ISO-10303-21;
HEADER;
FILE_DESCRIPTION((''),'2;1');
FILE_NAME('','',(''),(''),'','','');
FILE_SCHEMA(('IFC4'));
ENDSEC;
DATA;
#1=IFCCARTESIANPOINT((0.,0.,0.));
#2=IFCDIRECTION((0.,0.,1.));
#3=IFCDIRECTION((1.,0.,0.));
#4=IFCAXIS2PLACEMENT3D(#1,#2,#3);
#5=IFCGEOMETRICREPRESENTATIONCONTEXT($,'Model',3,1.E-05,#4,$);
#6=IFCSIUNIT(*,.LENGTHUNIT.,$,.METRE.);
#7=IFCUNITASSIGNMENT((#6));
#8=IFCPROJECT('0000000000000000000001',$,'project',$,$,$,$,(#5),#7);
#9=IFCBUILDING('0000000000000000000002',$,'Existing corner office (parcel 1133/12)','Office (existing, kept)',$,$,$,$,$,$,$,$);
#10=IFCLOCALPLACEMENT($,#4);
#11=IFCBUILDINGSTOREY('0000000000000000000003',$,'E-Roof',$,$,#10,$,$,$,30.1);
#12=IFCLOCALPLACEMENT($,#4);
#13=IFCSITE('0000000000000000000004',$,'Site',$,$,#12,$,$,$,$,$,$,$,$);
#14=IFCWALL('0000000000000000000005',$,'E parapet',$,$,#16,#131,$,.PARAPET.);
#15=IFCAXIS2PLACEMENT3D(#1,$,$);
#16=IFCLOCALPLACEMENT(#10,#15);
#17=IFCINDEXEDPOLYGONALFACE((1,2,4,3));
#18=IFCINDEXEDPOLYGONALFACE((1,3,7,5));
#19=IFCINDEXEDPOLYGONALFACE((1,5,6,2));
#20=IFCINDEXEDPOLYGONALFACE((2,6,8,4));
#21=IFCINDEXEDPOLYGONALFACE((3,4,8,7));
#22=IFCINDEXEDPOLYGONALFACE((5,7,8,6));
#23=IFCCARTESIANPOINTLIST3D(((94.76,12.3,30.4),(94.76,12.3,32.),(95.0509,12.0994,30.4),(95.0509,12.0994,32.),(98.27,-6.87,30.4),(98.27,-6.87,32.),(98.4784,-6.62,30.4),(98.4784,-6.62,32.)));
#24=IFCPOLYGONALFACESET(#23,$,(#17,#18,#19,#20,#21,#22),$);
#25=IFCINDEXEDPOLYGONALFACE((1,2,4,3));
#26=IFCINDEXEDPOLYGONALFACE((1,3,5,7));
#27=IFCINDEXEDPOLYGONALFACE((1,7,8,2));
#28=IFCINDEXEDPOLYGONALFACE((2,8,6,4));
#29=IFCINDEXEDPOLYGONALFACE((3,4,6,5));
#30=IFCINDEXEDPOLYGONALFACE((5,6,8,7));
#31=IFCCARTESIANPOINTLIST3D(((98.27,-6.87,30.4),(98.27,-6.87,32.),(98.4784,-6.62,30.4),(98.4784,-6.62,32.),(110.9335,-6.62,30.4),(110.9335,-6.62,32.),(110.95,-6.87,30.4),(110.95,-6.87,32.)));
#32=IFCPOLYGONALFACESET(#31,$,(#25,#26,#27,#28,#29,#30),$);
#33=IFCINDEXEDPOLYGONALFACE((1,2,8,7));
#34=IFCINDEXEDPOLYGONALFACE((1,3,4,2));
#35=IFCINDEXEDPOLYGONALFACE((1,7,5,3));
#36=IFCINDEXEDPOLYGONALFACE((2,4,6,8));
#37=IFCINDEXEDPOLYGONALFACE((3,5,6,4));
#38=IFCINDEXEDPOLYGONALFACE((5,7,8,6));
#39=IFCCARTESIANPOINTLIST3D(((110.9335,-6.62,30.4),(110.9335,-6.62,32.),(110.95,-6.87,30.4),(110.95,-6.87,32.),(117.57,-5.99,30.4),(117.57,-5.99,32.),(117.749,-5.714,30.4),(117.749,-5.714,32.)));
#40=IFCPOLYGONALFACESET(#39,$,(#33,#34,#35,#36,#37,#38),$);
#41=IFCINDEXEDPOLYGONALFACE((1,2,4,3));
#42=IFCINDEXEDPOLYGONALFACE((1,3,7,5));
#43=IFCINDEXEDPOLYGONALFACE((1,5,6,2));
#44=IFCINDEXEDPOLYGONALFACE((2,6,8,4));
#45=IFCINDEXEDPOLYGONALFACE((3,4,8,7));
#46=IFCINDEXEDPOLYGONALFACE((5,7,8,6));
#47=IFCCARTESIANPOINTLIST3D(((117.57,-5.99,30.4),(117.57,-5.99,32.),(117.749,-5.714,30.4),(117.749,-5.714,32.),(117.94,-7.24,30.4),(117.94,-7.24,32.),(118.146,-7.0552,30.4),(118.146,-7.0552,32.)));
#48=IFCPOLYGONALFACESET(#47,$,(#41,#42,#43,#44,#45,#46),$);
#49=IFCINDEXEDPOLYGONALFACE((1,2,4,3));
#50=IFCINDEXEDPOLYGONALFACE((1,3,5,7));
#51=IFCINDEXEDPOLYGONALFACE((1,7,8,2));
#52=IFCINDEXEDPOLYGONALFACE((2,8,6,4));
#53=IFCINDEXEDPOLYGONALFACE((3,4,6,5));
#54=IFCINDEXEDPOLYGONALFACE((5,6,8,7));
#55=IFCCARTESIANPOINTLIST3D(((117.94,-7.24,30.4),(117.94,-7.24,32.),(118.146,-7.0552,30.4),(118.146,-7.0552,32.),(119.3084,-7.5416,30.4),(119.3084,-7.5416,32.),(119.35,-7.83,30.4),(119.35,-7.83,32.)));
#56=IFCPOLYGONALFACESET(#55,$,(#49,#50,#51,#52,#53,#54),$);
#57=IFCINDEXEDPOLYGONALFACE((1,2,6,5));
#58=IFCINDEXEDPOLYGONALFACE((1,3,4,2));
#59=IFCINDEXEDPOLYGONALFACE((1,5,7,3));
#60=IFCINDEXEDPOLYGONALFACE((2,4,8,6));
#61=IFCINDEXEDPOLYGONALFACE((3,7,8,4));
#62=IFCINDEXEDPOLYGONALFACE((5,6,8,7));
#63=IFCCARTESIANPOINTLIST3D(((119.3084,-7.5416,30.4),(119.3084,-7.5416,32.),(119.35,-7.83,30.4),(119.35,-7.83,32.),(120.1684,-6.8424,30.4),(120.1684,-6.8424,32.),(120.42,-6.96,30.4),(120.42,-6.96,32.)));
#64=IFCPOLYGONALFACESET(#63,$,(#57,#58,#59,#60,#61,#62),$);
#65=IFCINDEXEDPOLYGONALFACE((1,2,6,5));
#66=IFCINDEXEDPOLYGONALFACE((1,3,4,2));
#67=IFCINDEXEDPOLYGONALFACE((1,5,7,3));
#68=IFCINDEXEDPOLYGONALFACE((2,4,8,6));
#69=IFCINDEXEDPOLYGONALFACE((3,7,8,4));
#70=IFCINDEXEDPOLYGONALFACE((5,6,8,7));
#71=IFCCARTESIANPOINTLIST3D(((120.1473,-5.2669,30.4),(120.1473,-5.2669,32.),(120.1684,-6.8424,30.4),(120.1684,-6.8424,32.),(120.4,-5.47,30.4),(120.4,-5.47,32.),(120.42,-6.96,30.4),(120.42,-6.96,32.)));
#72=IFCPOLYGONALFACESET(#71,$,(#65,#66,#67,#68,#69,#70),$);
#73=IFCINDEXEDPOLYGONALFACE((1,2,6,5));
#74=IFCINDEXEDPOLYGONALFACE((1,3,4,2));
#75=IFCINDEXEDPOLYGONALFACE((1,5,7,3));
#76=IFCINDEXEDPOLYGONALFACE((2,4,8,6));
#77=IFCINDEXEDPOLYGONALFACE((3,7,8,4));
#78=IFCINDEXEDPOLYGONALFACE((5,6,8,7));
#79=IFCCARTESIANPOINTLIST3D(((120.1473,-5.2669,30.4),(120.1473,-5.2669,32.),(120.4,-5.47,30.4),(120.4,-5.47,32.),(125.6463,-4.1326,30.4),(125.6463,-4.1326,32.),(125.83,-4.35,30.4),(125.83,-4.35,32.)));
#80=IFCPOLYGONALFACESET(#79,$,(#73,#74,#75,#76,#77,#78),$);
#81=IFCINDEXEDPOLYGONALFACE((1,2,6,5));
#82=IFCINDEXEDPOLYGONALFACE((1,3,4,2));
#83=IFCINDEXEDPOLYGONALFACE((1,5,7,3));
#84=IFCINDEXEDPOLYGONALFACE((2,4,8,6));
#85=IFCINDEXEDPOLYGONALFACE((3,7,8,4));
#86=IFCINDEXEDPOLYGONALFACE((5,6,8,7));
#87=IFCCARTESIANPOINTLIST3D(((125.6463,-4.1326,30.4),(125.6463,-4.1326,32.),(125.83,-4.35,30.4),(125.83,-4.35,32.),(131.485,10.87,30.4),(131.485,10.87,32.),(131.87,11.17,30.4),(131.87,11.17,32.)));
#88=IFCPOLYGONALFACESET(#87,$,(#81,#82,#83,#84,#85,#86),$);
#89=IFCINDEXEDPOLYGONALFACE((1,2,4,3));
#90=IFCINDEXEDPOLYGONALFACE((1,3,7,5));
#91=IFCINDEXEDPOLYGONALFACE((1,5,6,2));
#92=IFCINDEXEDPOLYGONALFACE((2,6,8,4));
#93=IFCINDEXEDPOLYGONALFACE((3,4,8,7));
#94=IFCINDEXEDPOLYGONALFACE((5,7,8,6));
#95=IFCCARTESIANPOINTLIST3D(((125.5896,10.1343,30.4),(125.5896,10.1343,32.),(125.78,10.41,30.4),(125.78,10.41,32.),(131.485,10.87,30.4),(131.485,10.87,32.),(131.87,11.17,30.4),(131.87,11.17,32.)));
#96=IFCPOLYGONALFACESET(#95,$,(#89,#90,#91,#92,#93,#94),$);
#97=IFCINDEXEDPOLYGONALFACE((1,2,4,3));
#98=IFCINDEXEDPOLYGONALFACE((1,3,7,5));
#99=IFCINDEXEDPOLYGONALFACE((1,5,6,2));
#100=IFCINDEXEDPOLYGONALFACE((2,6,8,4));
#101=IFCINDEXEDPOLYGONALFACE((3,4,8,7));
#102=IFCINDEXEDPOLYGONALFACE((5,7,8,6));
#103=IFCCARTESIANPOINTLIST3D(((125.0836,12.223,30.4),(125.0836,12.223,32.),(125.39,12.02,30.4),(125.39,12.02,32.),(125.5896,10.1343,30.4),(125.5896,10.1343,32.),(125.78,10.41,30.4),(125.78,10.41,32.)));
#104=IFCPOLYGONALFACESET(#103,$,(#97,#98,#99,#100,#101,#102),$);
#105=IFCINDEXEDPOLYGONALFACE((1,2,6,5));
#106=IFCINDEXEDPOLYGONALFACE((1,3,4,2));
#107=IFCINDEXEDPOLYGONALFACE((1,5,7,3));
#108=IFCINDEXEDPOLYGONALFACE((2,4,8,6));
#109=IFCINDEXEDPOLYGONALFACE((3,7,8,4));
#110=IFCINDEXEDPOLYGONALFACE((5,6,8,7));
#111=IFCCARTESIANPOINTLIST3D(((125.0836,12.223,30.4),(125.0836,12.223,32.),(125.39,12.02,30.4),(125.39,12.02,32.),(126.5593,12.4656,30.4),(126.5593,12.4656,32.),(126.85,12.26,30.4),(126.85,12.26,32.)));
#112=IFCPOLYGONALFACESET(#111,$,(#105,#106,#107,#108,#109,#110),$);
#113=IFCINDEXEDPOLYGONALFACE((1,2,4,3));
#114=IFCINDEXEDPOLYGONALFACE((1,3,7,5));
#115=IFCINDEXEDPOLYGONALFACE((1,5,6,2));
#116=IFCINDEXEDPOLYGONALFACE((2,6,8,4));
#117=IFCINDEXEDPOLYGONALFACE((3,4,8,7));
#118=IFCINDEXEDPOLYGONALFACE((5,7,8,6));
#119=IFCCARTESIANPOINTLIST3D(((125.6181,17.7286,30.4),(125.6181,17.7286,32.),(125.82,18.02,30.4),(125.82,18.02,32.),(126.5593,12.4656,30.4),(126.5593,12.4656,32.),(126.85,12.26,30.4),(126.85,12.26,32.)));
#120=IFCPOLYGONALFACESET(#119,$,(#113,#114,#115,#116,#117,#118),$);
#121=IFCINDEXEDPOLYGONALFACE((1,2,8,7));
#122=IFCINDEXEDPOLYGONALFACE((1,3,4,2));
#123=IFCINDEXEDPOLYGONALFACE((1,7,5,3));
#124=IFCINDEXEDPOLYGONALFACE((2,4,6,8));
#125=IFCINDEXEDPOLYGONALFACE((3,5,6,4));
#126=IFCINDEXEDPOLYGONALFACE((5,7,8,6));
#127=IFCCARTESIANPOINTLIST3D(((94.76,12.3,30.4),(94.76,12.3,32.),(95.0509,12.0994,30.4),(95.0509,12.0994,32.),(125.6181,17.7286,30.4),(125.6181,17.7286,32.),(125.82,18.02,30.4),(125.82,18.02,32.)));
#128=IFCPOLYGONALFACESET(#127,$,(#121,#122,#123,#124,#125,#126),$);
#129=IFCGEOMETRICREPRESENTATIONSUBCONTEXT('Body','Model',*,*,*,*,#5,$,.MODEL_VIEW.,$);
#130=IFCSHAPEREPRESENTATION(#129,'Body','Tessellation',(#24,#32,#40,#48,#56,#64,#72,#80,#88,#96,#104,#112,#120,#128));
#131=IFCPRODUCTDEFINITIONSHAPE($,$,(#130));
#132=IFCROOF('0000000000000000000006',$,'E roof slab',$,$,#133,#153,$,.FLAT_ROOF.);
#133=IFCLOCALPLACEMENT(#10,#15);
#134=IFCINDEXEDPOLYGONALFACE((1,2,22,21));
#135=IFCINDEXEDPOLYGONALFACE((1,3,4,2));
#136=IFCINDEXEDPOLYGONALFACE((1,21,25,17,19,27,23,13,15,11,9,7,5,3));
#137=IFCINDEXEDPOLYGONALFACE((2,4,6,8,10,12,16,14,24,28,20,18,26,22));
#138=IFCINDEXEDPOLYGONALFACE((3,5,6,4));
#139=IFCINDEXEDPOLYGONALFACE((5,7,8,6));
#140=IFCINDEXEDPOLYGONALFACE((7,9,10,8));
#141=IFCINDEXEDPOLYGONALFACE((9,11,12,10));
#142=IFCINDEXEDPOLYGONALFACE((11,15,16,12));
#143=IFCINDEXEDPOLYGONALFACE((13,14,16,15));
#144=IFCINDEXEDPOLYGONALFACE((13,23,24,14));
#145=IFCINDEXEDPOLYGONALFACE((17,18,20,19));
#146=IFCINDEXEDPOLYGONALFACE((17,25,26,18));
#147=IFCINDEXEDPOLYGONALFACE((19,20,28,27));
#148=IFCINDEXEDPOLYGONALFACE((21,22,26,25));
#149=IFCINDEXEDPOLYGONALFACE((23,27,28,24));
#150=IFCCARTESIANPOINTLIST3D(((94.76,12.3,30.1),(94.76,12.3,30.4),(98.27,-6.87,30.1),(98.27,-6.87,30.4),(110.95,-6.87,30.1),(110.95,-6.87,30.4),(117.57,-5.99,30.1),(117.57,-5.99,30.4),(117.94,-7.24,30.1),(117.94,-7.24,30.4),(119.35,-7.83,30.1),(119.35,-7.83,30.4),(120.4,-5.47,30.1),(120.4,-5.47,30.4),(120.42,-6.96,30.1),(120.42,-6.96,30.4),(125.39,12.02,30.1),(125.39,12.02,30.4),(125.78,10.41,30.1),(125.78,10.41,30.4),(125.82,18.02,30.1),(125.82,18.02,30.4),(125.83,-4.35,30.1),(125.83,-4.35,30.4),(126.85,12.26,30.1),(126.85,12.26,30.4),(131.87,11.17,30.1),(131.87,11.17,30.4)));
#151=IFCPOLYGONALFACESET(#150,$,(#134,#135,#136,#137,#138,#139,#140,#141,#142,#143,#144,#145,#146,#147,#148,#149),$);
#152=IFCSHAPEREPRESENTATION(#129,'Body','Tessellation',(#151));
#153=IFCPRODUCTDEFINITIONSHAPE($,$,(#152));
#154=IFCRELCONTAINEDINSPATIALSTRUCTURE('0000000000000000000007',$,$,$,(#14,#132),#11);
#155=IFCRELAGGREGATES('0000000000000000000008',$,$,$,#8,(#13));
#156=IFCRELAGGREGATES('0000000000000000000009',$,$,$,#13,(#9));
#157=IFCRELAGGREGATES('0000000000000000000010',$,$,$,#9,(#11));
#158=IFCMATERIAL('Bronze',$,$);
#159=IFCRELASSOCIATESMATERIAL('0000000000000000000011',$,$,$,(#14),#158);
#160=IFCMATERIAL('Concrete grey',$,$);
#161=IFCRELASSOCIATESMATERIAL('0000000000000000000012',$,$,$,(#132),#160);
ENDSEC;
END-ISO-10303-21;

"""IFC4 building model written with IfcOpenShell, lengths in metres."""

from ifc_helpers import new_model, si_unit, frame, origin_with_axes, place, context, subcontext, project, spatial, polyline, outline, extrude, material, element, save


model = new_model("IFC4")

# Units and contexts
model_context = context("Model", 3, precision=1e-05, world=origin_with_axes())
body_context = subcontext(model_context, "Body", "Model", "MODEL_VIEW")
ifc_project = project(units=[si_unit("LENGTHUNIT", "METRE")], contexts=[model_context])

# Site, building, storey
site_placement = place(None, origin_with_axes())
site = spatial("IfcSite", under=ifc_project, at=site_placement, Name="Site")
building = spatial("IfcBuilding", under=site, Name="Existing corner office (parcel 1133/12)", Description="Office (existing, kept)")
storey_placement = place(None, origin_with_axes())
storey = spatial("IfcBuildingStorey", under=building, at=storey_placement, Name="E-Roof", Elevation=30.1)

# Wall
ifc_material_1 = material(Name="Bronze")
wall_placement = place(storey_placement, origin_with_axes())
element("IfcWall", 1, at=wall_placement, inside=storey, material=ifc_material_1, Name="E parapet", PredefinedType="PARAPET", context=body_context, shape_type="SweptSolid", body=[
    extrude(outline(polyline([(94.76, 12.3), (98.27, -6.87), (98.4784, -6.62), (95.0509, 12.0994), (94.76, 12.3)])), frame((0.0, 0.0, 30.4), z_axis=(0.0, 0.0, 1.0), x_axis=(1.0, 0.0, 0.0)), (0.0, 0.0, 1.0), 1.6),
    extrude(outline(polyline([(98.27, -6.87), (110.95, -6.87), (110.9335, -6.62), (98.4784, -6.62), (98.27, -6.87)])), frame((0.0, 0.0, 30.4), z_axis=(0.0, 0.0, 1.0), x_axis=(1.0, 0.0, 0.0)), (0.0, 0.0, 1.0), 1.6),
    extrude(outline(polyline([(110.95, -6.87), (117.57, -5.99), (117.749, -5.714), (110.9335, -6.62), (110.95, -6.87)])), frame((0.0, 0.0, 30.4), z_axis=(0.0, 0.0, 1.0), x_axis=(1.0, 0.0, 0.0)), (0.0, 0.0, 1.0), 1.6),
    extrude(outline(polyline([(117.57, -5.99), (117.94, -7.24), (118.146, -7.0552), (117.749, -5.714), (117.57, -5.99)])), frame((0.0, 0.0, 30.4), z_axis=(0.0, 0.0, 1.0), x_axis=(1.0, 0.0, 0.0)), (0.0, 0.0, 1.0), 1.6),
    extrude(outline(polyline([(117.94, -7.24), (119.35, -7.83), (119.3084, -7.5416), (118.146, -7.0552), (117.94, -7.24)])), frame((0.0, 0.0, 30.4), z_axis=(0.0, 0.0, 1.0), x_axis=(1.0, 0.0, 0.0)), (0.0, 0.0, 1.0), 1.6),
    extrude(outline(polyline([(119.35, -7.83), (120.42, -6.96), (120.1684, -6.8424), (119.3084, -7.5416), (119.35, -7.83)])), frame((0.0, 0.0, 30.4), z_axis=(0.0, 0.0, 1.0), x_axis=(1.0, 0.0, 0.0)), (0.0, 0.0, 1.0), 1.6),
    extrude(outline(polyline([(120.42, -6.96), (120.4, -5.47), (120.1473, -5.2669), (120.1684, -6.8424), (120.42, -6.96)])), frame((0.0, 0.0, 30.4), z_axis=(0.0, 0.0, 1.0), x_axis=(1.0, 0.0, 0.0)), (0.0, 0.0, 1.0), 1.6),
    extrude(outline(polyline([(120.4, -5.47), (125.83, -4.35), (125.6463, -4.1326), (120.1473, -5.2669), (120.4, -5.47)])), frame((0.0, 0.0, 30.4), z_axis=(0.0, 0.0, 1.0), x_axis=(1.0, 0.0, 0.0)), (0.0, 0.0, 1.0), 1.6),
    extrude(outline(polyline([(125.83, -4.35), (131.87, 11.17), (131.485, 10.87), (125.6463, -4.1326), (125.83, -4.35)])), frame((0.0, 0.0, 30.4), z_axis=(0.0, 0.0, 1.0), x_axis=(1.0, 0.0, 0.0)), (0.0, 0.0, 1.0), 1.6),
    extrude(outline(polyline([(131.87, 11.17), (125.78, 10.41), (125.5896, 10.1343), (131.485, 10.87), (131.87, 11.17)])), frame((0.0, 0.0, 30.4), z_axis=(0.0, 0.0, 1.0), x_axis=(1.0, 0.0, 0.0)), (0.0, 0.0, 1.0), 1.6),
    extrude(outline(polyline([(125.78, 10.41), (125.39, 12.02), (125.0836, 12.223), (125.5896, 10.1343), (125.78, 10.41)])), frame((0.0, 0.0, 30.4), z_axis=(0.0, 0.0, 1.0), x_axis=(1.0, 0.0, 0.0)), (0.0, 0.0, 1.0), 1.6),
    extrude(outline(polyline([(125.39, 12.02), (126.85, 12.26), (126.5593, 12.4656), (125.0836, 12.223), (125.39, 12.02)])), frame((0.0, 0.0, 30.4), z_axis=(0.0, 0.0, 1.0), x_axis=(1.0, 0.0, 0.0)), (0.0, 0.0, 1.0), 1.6),
    extrude(outline(polyline([(126.85, 12.26), (125.82, 18.02), (125.6181, 17.7286), (126.5593, 12.4656), (126.85, 12.26)])), frame((0.0, 0.0, 30.4), z_axis=(0.0, 0.0, 1.0), x_axis=(1.0, 0.0, 0.0)), (0.0, 0.0, 1.0), 1.6),
    extrude(outline(polyline([(125.82, 18.02), (94.76, 12.3), (95.0509, 12.0994), (125.6181, 17.7286), (125.82, 18.02)])), frame((0.0, 0.0, 30.4), z_axis=(0.0, 0.0, 1.0), x_axis=(1.0, 0.0, 0.0)), (0.0, 0.0, 1.0), 1.6),
])

# Roof
ifc_material_2 = material(Name="Concrete grey")
roof_placement = place(storey_placement, origin_with_axes())
element("IfcRoof", 2, at=roof_placement, inside=storey, material=ifc_material_2, Name="E roof slab", PredefinedType="FLAT_ROOF", context=body_context, shape_type="SweptSolid", body=[
    extrude(outline(polyline([(94.76, 12.3), (98.27, -6.87), (110.95, -6.87), (117.57, -5.99), (117.94, -7.24), (119.35, -7.83), (120.42, -6.96), (120.4, -5.47), (125.83, -4.35), (131.87, 11.17), (125.78, 10.41), (125.39, 12.02), (126.85, 12.26), (125.82, 18.02), (94.76, 12.3)])), frame((0.0, 0.0, 30.1), z_axis=(0.0, 0.0, 1.0), x_axis=(1.0, 0.0, 0.0)), (0.0, 0.0, 1.0), 0.3),
])

save(model, "model.ifc")
